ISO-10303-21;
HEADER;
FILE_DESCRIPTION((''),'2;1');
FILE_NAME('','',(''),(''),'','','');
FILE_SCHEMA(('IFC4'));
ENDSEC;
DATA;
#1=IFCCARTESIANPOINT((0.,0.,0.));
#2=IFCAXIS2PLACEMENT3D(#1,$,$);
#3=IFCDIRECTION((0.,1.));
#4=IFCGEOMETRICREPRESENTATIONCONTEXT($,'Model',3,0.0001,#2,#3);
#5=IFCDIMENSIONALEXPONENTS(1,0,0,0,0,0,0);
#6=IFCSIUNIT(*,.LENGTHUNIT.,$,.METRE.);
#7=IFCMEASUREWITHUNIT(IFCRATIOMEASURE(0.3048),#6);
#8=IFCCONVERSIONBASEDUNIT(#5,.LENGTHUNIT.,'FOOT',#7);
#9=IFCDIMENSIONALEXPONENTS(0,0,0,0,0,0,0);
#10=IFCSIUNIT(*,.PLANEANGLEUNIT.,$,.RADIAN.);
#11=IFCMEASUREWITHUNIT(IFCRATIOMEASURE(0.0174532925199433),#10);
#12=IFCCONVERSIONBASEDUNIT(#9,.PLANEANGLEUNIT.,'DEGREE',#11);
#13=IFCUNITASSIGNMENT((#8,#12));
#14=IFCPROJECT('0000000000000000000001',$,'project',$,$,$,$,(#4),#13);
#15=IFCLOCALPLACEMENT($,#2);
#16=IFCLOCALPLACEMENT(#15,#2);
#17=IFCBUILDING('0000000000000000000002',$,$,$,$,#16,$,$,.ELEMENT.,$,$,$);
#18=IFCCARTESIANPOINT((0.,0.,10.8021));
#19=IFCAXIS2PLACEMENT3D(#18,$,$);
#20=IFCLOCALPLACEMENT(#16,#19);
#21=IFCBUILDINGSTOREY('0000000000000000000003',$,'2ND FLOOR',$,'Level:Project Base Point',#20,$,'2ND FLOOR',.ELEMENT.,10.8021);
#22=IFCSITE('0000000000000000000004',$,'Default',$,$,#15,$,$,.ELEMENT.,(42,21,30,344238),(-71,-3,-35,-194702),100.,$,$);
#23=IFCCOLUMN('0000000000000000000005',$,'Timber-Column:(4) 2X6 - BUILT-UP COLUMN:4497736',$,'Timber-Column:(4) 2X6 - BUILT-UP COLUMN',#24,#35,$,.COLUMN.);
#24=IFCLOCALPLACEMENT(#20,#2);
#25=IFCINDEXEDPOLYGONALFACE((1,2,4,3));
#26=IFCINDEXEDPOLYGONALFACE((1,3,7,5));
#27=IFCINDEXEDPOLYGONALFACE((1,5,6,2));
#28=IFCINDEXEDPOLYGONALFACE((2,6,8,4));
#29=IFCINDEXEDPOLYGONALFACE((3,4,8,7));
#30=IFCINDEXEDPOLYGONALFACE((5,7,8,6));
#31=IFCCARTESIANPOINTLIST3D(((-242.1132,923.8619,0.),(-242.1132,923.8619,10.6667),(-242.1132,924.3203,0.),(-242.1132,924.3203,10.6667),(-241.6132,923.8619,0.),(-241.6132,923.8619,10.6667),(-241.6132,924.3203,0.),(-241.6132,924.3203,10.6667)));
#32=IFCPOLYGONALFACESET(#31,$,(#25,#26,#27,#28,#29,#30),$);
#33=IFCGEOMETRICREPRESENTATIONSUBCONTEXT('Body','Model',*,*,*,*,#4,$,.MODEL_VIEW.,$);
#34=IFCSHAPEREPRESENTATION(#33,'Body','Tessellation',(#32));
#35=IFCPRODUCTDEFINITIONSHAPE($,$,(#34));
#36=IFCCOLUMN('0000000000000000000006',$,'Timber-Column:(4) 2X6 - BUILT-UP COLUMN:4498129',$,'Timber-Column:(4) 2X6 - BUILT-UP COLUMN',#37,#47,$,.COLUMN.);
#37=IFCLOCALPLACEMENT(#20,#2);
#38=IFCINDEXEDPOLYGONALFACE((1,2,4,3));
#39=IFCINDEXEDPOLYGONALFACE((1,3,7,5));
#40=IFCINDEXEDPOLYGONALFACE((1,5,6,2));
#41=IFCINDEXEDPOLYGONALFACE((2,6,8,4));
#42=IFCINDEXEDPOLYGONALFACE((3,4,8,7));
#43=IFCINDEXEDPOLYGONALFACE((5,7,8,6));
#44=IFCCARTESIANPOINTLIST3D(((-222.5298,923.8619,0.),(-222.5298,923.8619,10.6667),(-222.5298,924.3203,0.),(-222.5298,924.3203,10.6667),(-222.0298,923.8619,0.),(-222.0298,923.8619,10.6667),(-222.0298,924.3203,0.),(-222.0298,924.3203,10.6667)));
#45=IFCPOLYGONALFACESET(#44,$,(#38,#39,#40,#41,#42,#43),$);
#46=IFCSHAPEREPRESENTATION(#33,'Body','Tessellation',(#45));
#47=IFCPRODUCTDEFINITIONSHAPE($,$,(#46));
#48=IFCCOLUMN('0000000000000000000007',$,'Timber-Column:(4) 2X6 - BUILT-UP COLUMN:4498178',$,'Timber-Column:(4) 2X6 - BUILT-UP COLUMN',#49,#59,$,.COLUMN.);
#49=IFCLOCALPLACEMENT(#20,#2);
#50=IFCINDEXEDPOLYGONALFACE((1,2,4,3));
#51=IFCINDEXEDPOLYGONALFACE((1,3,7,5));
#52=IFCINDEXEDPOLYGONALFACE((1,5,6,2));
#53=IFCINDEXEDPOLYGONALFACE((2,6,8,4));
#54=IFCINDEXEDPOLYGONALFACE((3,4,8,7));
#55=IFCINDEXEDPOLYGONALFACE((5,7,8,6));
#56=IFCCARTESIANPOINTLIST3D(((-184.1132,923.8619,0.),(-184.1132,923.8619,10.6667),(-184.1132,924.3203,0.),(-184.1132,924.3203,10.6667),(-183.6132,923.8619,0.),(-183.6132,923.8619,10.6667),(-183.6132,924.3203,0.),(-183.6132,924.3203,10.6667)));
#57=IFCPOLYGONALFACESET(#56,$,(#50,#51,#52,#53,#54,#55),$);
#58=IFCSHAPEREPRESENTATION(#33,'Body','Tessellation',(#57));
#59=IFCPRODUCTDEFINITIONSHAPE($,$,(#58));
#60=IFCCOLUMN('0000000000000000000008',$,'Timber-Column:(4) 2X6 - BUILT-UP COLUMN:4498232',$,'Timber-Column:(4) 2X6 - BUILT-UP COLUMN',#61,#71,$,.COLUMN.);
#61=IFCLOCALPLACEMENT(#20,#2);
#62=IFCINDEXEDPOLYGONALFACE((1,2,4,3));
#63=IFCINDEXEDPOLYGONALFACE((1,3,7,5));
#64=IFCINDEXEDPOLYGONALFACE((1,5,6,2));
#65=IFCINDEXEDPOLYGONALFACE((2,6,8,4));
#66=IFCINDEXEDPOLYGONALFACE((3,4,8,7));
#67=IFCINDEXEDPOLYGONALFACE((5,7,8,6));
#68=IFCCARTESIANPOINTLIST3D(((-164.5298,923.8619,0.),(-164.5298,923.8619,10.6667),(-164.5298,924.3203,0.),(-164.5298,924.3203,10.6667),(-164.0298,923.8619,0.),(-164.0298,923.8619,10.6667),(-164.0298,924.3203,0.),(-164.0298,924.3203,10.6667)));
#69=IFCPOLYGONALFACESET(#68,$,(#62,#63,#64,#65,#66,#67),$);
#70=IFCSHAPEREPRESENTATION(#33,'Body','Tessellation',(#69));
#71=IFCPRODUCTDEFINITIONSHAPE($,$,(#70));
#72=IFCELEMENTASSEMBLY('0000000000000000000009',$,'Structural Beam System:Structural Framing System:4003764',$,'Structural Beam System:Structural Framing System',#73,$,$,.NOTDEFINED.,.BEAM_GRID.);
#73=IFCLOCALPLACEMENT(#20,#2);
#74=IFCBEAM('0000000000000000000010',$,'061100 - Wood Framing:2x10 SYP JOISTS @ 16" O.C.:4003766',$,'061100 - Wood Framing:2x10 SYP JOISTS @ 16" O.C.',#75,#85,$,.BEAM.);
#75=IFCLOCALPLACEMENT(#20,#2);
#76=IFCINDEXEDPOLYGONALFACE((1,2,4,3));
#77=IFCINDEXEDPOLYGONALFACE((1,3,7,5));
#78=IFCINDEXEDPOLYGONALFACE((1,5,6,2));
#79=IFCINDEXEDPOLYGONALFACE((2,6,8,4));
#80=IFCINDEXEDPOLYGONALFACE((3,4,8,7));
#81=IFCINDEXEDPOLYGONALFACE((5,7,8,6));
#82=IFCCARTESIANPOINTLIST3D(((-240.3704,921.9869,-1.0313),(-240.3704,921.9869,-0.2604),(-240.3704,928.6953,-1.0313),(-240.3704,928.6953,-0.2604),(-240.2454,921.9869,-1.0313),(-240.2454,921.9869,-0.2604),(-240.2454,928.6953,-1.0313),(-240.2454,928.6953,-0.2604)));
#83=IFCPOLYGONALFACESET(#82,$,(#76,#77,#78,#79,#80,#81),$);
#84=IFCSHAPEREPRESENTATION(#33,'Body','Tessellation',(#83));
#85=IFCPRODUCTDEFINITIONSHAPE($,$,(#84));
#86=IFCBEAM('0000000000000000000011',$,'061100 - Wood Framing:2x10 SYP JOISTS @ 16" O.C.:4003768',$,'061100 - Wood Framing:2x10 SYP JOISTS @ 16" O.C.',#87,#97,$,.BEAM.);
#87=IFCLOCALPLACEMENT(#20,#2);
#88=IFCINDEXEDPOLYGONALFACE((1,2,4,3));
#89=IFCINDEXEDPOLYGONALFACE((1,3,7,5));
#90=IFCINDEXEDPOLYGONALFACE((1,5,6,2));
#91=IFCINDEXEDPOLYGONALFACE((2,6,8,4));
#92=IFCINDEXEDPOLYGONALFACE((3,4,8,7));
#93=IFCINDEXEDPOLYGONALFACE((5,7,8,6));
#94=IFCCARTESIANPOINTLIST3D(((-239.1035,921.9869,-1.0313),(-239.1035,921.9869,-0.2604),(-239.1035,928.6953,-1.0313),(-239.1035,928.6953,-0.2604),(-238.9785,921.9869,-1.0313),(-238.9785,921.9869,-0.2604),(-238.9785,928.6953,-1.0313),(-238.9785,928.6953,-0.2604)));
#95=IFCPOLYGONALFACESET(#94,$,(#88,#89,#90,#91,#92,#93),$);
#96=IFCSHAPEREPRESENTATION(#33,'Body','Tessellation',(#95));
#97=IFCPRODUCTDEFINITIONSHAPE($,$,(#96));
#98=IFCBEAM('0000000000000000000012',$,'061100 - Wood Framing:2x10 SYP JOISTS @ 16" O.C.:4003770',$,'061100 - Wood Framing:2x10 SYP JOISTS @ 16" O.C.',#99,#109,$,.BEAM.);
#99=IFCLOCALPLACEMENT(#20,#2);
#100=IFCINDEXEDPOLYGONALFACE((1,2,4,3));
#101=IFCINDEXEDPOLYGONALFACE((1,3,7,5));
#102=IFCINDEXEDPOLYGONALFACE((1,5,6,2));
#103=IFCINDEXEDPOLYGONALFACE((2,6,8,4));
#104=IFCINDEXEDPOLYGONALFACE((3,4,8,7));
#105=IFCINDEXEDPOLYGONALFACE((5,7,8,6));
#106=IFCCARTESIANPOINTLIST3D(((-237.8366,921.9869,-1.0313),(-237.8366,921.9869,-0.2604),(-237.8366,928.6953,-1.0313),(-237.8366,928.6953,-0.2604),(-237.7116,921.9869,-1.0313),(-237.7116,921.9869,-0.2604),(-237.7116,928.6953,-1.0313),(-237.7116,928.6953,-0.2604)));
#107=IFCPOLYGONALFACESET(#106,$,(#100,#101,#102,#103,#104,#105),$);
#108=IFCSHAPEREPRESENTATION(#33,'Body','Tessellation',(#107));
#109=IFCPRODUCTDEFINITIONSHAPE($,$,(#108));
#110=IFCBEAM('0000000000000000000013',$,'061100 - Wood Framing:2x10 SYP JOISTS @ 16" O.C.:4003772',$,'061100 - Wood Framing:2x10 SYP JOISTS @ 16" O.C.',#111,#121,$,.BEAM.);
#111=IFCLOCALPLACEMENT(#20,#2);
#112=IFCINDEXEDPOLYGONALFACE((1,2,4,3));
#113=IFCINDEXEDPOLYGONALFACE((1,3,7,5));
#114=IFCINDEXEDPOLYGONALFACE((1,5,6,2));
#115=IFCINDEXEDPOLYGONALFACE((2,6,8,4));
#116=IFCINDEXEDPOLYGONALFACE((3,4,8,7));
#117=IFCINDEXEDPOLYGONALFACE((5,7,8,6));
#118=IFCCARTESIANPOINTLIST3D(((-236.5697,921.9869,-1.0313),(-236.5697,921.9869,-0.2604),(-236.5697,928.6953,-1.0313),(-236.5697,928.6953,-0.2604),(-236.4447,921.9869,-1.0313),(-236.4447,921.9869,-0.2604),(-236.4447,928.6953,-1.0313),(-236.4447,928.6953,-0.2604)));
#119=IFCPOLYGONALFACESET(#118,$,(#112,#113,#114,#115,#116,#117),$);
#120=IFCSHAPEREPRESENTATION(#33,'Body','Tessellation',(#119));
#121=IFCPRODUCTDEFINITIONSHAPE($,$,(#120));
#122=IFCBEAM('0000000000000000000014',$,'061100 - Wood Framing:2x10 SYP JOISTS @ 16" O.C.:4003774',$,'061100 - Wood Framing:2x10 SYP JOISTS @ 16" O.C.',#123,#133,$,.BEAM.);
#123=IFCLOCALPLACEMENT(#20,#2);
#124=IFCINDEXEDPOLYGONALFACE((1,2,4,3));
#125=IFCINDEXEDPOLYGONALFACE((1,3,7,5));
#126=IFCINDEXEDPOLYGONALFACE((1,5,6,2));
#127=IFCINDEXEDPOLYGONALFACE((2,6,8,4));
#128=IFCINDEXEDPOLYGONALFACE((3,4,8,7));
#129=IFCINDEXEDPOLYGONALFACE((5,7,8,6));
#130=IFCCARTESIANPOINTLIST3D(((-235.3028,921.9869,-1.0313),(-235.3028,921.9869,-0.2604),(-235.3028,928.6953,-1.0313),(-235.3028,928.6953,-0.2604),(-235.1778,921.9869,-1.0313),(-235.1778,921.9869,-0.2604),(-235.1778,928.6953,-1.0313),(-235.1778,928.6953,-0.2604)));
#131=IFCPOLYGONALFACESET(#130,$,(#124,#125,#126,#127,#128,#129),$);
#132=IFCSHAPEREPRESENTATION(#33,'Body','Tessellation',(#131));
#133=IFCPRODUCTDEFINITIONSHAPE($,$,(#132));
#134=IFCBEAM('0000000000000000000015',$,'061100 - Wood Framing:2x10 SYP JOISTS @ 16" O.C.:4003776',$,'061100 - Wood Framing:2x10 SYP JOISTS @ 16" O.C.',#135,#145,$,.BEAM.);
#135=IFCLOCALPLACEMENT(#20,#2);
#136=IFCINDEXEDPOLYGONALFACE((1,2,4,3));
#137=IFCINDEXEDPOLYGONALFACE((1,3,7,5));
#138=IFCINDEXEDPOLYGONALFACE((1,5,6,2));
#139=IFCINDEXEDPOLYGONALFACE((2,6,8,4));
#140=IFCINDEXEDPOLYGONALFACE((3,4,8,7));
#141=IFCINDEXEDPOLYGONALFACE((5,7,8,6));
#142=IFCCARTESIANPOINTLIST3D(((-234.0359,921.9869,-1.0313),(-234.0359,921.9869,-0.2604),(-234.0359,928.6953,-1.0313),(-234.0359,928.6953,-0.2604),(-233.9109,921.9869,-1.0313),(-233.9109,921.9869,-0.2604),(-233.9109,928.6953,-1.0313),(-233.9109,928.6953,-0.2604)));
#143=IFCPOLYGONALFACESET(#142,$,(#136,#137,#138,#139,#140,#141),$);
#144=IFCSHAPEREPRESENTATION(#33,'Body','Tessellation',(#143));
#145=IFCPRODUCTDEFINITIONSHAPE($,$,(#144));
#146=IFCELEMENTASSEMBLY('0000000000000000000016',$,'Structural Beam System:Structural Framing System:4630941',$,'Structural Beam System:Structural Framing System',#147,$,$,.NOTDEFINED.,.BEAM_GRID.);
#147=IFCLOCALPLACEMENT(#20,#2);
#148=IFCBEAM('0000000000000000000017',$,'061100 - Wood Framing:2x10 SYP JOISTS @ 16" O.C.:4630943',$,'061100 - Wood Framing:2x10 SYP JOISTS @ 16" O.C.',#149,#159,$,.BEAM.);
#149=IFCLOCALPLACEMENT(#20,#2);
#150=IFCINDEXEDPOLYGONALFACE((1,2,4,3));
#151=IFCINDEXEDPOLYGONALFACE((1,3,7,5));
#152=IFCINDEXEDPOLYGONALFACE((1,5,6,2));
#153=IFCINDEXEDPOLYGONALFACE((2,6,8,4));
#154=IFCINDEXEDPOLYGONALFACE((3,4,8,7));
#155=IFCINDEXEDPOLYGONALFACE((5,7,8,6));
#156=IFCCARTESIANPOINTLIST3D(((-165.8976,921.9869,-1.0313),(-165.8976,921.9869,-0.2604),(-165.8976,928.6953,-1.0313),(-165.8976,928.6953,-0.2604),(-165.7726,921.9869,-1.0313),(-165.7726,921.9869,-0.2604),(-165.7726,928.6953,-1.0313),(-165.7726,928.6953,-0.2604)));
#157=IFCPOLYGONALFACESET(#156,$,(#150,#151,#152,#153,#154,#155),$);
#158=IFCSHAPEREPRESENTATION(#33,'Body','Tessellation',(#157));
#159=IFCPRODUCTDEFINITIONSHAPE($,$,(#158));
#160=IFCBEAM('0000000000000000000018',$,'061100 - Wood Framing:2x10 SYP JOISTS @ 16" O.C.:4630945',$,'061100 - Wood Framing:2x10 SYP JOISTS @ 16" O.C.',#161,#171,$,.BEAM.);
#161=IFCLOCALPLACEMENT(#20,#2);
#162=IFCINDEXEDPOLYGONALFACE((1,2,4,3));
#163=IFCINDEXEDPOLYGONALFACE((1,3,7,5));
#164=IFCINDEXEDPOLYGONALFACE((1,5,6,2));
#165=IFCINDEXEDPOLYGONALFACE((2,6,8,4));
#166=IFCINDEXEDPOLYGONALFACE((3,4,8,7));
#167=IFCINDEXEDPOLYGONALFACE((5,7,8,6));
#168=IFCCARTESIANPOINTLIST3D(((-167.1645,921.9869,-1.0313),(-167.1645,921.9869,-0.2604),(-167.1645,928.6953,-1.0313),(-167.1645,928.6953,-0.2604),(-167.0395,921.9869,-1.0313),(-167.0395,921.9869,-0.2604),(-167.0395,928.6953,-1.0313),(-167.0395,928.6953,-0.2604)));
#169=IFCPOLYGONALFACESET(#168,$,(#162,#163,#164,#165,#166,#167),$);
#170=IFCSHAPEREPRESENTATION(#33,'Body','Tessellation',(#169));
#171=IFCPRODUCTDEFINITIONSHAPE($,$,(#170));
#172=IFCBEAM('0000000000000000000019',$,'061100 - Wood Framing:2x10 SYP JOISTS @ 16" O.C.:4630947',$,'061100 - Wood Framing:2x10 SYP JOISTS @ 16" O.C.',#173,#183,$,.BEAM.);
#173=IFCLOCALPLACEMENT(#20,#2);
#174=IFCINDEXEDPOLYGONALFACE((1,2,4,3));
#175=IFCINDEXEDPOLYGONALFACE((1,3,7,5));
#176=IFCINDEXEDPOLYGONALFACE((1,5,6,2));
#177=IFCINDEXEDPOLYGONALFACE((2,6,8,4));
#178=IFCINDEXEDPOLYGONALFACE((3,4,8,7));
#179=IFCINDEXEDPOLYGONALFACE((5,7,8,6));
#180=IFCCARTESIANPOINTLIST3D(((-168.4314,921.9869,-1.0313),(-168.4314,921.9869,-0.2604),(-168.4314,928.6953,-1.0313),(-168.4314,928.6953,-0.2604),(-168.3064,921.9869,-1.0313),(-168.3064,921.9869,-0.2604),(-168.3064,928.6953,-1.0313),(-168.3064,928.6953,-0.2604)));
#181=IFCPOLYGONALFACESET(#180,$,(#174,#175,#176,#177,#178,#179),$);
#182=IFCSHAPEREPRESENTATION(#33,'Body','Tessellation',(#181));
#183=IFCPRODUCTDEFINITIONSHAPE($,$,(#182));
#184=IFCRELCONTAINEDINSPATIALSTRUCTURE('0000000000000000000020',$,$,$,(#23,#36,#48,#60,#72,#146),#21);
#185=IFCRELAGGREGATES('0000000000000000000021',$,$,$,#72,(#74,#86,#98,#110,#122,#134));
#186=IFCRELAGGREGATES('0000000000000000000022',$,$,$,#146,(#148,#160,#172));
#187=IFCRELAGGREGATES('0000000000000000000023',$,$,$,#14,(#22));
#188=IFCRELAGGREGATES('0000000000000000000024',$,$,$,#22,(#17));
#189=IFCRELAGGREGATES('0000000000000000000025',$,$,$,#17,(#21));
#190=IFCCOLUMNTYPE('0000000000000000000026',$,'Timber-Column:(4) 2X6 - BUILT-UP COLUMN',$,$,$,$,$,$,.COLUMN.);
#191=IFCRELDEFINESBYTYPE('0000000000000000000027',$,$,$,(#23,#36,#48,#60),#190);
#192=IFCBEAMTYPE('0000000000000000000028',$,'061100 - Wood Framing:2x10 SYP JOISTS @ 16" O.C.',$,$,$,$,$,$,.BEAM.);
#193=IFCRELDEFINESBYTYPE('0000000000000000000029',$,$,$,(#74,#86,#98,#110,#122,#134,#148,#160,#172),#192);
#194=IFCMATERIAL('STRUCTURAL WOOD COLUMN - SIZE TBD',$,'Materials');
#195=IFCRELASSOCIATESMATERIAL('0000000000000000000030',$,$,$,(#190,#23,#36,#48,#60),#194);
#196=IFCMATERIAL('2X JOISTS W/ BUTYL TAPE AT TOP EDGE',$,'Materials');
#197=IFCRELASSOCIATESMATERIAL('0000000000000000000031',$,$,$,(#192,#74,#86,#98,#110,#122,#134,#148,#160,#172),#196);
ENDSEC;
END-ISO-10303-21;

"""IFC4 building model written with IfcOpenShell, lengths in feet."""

from ifc_helpers import new_model, entity, si_unit, converted_unit, direction, frame, frame_2d, origin, place, context, subcontext, project, spatial, rectangle, extrude, source, transform, mapped, material, material_profile, profile_set, profile_usage, type_object, type_shapes, element, aggregate, save


model = new_model("IFC4")

# Units and contexts
model_context = context("Model", 3, precision=0.0001, world=origin(), true_north=direction((0.0, 1.0)))
body_context = subcontext(model_context, "Body", "Model", "MODEL_VIEW")
ifc_project = project(units=[converted_unit("LENGTHUNIT", "FOOT", entity("IfcRatioMeasure", 0.3048), si_unit("LENGTHUNIT", "METRE"), dimensions=[1, 0, 0, 0, 0, 0, 0]), converted_unit("PLANEANGLEUNIT", "DEGREE", entity("IfcRatioMeasure", 0.0174532925199433), si_unit("PLANEANGLEUNIT", "RADIAN"), dimensions=[0, 0, 0, 0, 0, 0, 0])], contexts=[model_context])

# Site, building, storey
site_placement = place(None, origin())
site = spatial("IfcSite", under=ifc_project, at=site_placement, Name="Default", CompositionType="ELEMENT", RefLatitude=(42, 21, 30, 344238), RefLongitude=(-71, -3, -35, -194702), RefElevation=100.0)
building_placement = place(site_placement, origin())
building = spatial("IfcBuilding", under=site, at=building_placement, CompositionType="ELEMENT")
storey_placement = place(building_placement, frame((0.0, 0.0, 10.8021)))
storey = spatial("IfcBuildingStorey", under=building, at=storey_placement, Name="2ND FLOOR", ObjectType="Level:Project Base Point", LongName="2ND FLOOR", CompositionType="ELEMENT", Elevation=10.8021)

# Columns
ifc_material_1 = material(Name="STRUCTURAL WOOD COLUMN - SIZE TBD", Category="Materials")
ifc_material_profile_1 = material_profile(ifc_material_1, rectangle(XDim=0.4583, YDim=0.5, at=frame_2d((0.0, 0.0), x_axis=(1.0, 0.0))), Name="(4) 2X6 - BUILT-UP COLUMN")
ifc_profile_set_1 = profile_set([ifc_material_profile_1], Name="(4) 2X6 - BUILT-UP COLUMN")
ifc_profile_usage_1 = profile_usage(ifc_profile_set_1)
column_type = type_object("IfcColumnType", Name="Timber-Column:(4) 2X6 - BUILT-UP COLUMN", PredefinedType="COLUMN", material=ifc_profile_set_1)
shared_shape_1 = source(origin(), body_context, "Body", "SweptSolid", [
    extrude(rectangle(XDim=0.4583, YDim=0.5, at=frame_2d((0.0, 0.0), x_axis=(1.0, 0.0))), frame((0.0, 0.0, 10.8021), z_axis=(0.0, 0.0, 1.0), x_axis=(0.0, -1.0, 0.0)), (0.0, 0.0, 1.0), 10.6667),
])
type_shapes(column_type, [shared_shape_1])
column_1_placement = place(storey_placement, frame((-241.8632, 924.0911, -10.8021)))
element("IfcColumn", 1, at=column_1_placement, inside=storey, type_object=column_type, material=ifc_profile_usage_1, Name="Timber-Column:(4) 2X6 - BUILT-UP COLUMN:4497736", ObjectType="Timber-Column:(4) 2X6 - BUILT-UP COLUMN", PredefinedType="COLUMN", context=body_context, shape_type="MappedRepresentation", body=[
    mapped(shared_shape_1, transform((0.0, 0.0, 0.0), scale=1.0)),
])
ifc_profile_usage_2 = profile_usage(ifc_profile_set_1)
column_2_placement = place(storey_placement, frame((-222.2798, 924.0911, -10.8021)))
element("IfcColumn", 2, at=column_2_placement, inside=storey, type_object=column_type, material=ifc_profile_usage_2, Name="Timber-Column:(4) 2X6 - BUILT-UP COLUMN:4498129", ObjectType="Timber-Column:(4) 2X6 - BUILT-UP COLUMN", PredefinedType="COLUMN", context=body_context, shape_type="MappedRepresentation", body=[
    mapped(shared_shape_1, transform((0.0, 0.0, 0.0), scale=1.0)),
])
ifc_profile_usage_3 = profile_usage(ifc_profile_set_1)
column_3_placement = place(storey_placement, frame((-183.8632, 924.0911, -10.8021)))
element("IfcColumn", 3, at=column_3_placement, inside=storey, type_object=column_type, material=ifc_profile_usage_3, Name="Timber-Column:(4) 2X6 - BUILT-UP COLUMN:4498178", ObjectType="Timber-Column:(4) 2X6 - BUILT-UP COLUMN", PredefinedType="COLUMN", context=body_context, shape_type="MappedRepresentation", body=[
    mapped(shared_shape_1, transform((0.0, 0.0, 0.0), scale=1.0)),
])
ifc_profile_usage_4 = profile_usage(ifc_profile_set_1)
column_4_placement = place(storey_placement, frame((-164.2798, 924.0911, -10.8021)))
element("IfcColumn", 4, at=column_4_placement, inside=storey, type_object=column_type, material=ifc_profile_usage_4, Name="Timber-Column:(4) 2X6 - BUILT-UP COLUMN:4498232", ObjectType="Timber-Column:(4) 2X6 - BUILT-UP COLUMN", PredefinedType="COLUMN", context=body_context, shape_type="MappedRepresentation", body=[
    mapped(shared_shape_1, transform((0.0, 0.0, 0.0), scale=1.0)),
])

# Element assemblies, beams
assembly_1_placement = place(storey_placement, origin())
assembly_1 = element("IfcElementAssembly", 5, at=assembly_1_placement, inside=storey, Name="Structural Beam System:Structural Framing System:4003764", ObjectType="Structural Beam System:Structural Framing System", AssemblyPlace="NOTDEFINED", PredefinedType="BEAM_GRID")
ifc_material_2 = material(Name="2X JOISTS W/ BUTYL TAPE AT TOP EDGE", Category="Materials")
ifc_material_profile_2 = material_profile(ifc_material_2, rectangle(XDim=0.7708, YDim=0.125, at=frame_2d((0.0, 0.0), x_axis=(1.0, 0.0))), Name="2x10 SYP JOISTS @ 16\" O.C.")
ifc_profile_set_2 = profile_set([ifc_material_profile_2], Name="2x10 SYP JOISTS @ 16\" O.C.")
ifc_profile_usage_5 = profile_usage(ifc_profile_set_2, cardinal=8)
beam_type_1 = type_object("IfcBeamType", Name="061100 - Wood Framing:2x10 SYP JOISTS @ 16\" O.C.", PredefinedType="BEAM", material=ifc_profile_set_2)
shared_shape_2 = source(origin(), body_context, "Body", "SweptSolid", [
    extrude(rectangle(XDim=0.7708, YDim=0.125, at=frame_2d((0.0, 0.0), x_axis=(1.0, 0.0))), frame((-3.3542, 0.0, 0.0), z_axis=(1.0, 0.0, 0.0), x_axis=(0.0, 0.0, -1.0)), (0.0, 0.0, 1.0), 6.7083),
])
type_shapes(beam_type_1, [shared_shape_2])
beam_1_placement = place(assembly_1_placement, frame((-240.3079, 925.3411, -0.6458), z_axis=(0.0, 0.0, 1.0), x_axis=(0.0, 1.0, 0.0)))
beam_1 = element("IfcBeam", 6, at=beam_1_placement, type_object=beam_type_1, material=ifc_profile_usage_5, Name="061100 - Wood Framing:2x10 SYP JOISTS @ 16\" O.C.:4003766", ObjectType="061100 - Wood Framing:2x10 SYP JOISTS @ 16\" O.C.", PredefinedType="BEAM", context=body_context, shape_type="MappedRepresentation", body=[
    mapped(shared_shape_2, transform((0.0, 0.0, 0.0), scale=1.0)),
])
ifc_profile_usage_6 = profile_usage(ifc_profile_set_2, cardinal=8)
beam_2_placement = place(assembly_1_placement, frame((-239.041, 925.3411, -0.6458), z_axis=(0.0, 0.0, 1.0), x_axis=(0.0, 1.0, 0.0)))
beam_2 = element("IfcBeam", 7, at=beam_2_placement, type_object=beam_type_1, material=ifc_profile_usage_6, Name="061100 - Wood Framing:2x10 SYP JOISTS @ 16\" O.C.:4003768", ObjectType="061100 - Wood Framing:2x10 SYP JOISTS @ 16\" O.C.", PredefinedType="BEAM", context=body_context, shape_type="MappedRepresentation", body=[
    mapped(shared_shape_2, transform((0.0, 0.0, 0.0), scale=1.0)),
])
ifc_profile_usage_7 = profile_usage(ifc_profile_set_2, cardinal=8)
beam_3_placement = place(assembly_1_placement, frame((-237.7741, 925.3411, -0.6458), z_axis=(0.0, 0.0, 1.0), x_axis=(0.0, 1.0, 0.0)))
beam_3 = element("IfcBeam", 8, at=beam_3_placement, type_object=beam_type_1, material=ifc_profile_usage_7, Name="061100 - Wood Framing:2x10 SYP JOISTS @ 16\" O.C.:4003770", ObjectType="061100 - Wood Framing:2x10 SYP JOISTS @ 16\" O.C.", PredefinedType="BEAM", context=body_context, shape_type="MappedRepresentation", body=[
    mapped(shared_shape_2, transform((0.0, 0.0, 0.0), scale=1.0)),
])
ifc_profile_usage_8 = profile_usage(ifc_profile_set_2, cardinal=8)
beam_4_placement = place(assembly_1_placement, frame((-236.5072, 925.3411, -0.6458), z_axis=(0.0, 0.0, 1.0), x_axis=(0.0, 1.0, 0.0)))
beam_4 = element("IfcBeam", 9, at=beam_4_placement, type_object=beam_type_1, material=ifc_profile_usage_8, Name="061100 - Wood Framing:2x10 SYP JOISTS @ 16\" O.C.:4003772", ObjectType="061100 - Wood Framing:2x10 SYP JOISTS @ 16\" O.C.", PredefinedType="BEAM", context=body_context, shape_type="MappedRepresentation", body=[
    mapped(shared_shape_2, transform((0.0, 0.0, 0.0), scale=1.0)),
])
ifc_profile_usage_9 = profile_usage(ifc_profile_set_2, cardinal=8)
beam_5_placement = place(assembly_1_placement, frame((-235.2403, 925.3411, -0.6458), z_axis=(0.0, 0.0, 1.0), x_axis=(0.0, 1.0, 0.0)))
beam_5 = element("IfcBeam", 10, at=beam_5_placement, type_object=beam_type_1, material=ifc_profile_usage_9, Name="061100 - Wood Framing:2x10 SYP JOISTS @ 16\" O.C.:4003774", ObjectType="061100 - Wood Framing:2x10 SYP JOISTS @ 16\" O.C.", PredefinedType="BEAM", context=body_context, shape_type="MappedRepresentation", body=[
    mapped(shared_shape_2, transform((0.0, 0.0, 0.0), scale=1.0)),
])
ifc_profile_usage_10 = profile_usage(ifc_profile_set_2, cardinal=8)
beam_6_placement = place(assembly_1_placement, frame((-233.9734, 925.3411, -0.6458), z_axis=(0.0, 0.0, 1.0), x_axis=(0.0, 1.0, 0.0)))
beam_6 = element("IfcBeam", 11, at=beam_6_placement, type_object=beam_type_1, material=ifc_profile_usage_10, Name="061100 - Wood Framing:2x10 SYP JOISTS @ 16\" O.C.:4003776", ObjectType="061100 - Wood Framing:2x10 SYP JOISTS @ 16\" O.C.", PredefinedType="BEAM", context=body_context, shape_type="MappedRepresentation", body=[
    mapped(shared_shape_2, transform((0.0, 0.0, 0.0), scale=1.0)),
])
aggregate(assembly_1, [beam_1, beam_2, beam_3, beam_4, beam_5, beam_6])
assembly_2_placement = place(storey_placement, origin())
assembly_2 = element("IfcElementAssembly", 12, at=assembly_2_placement, inside=storey, Name="Structural Beam System:Structural Framing System:4630941", ObjectType="Structural Beam System:Structural Framing System", AssemblyPlace="NOTDEFINED", PredefinedType="BEAM_GRID")
ifc_profile_usage_11 = profile_usage(ifc_profile_set_2, cardinal=8)
beam_7_placement = place(assembly_2_placement, frame((-165.8351, 925.3411, -0.6458), z_axis=(0.0, 0.0, 1.0), x_axis=(0.0, 1.0, 0.0)))
beam_7 = element("IfcBeam", 13, at=beam_7_placement, type_object=beam_type_1, material=ifc_profile_usage_11, Name="061100 - Wood Framing:2x10 SYP JOISTS @ 16\" O.C.:4630943", ObjectType="061100 - Wood Framing:2x10 SYP JOISTS @ 16\" O.C.", PredefinedType="BEAM", context=body_context, shape_type="MappedRepresentation", body=[
    mapped(shared_shape_2, transform((0.0, 0.0, 0.0), scale=1.0)),
])
ifc_profile_usage_12 = profile_usage(ifc_profile_set_2, cardinal=8)
beam_8_placement = place(assembly_2_placement, frame((-167.102, 925.3411, -0.6458), z_axis=(0.0, 0.0, 1.0), x_axis=(0.0, 1.0, 0.0)))
beam_8 = element("IfcBeam", 14, at=beam_8_placement, type_object=beam_type_1, material=ifc_profile_usage_12, Name="061100 - Wood Framing:2x10 SYP JOISTS @ 16\" O.C.:4630945", ObjectType="061100 - Wood Framing:2x10 SYP JOISTS @ 16\" O.C.", PredefinedType="BEAM", context=body_context, shape_type="MappedRepresentation", body=[
    mapped(shared_shape_2, transform((0.0, 0.0, 0.0), scale=1.0)),
])
ifc_profile_usage_13 = profile_usage(ifc_profile_set_2, cardinal=8)
beam_9_placement = place(assembly_2_placement, frame((-168.3689, 925.3411, -0.6458), z_axis=(0.0, 0.0, 1.0), x_axis=(0.0, 1.0, 0.0)))
beam_9 = element("IfcBeam", 15, at=beam_9_placement, type_object=beam_type_1, material=ifc_profile_usage_13, Name="061100 - Wood Framing:2x10 SYP JOISTS @ 16\" O.C.:4630947", ObjectType="061100 - Wood Framing:2x10 SYP JOISTS @ 16\" O.C.", PredefinedType="BEAM", context=body_context, shape_type="MappedRepresentation", body=[
    mapped(shared_shape_2, transform((0.0, 0.0, 0.0), scale=1.0)),
])
aggregate(assembly_2, [beam_7, beam_8, beam_9])

save(model, "model.ifc")
